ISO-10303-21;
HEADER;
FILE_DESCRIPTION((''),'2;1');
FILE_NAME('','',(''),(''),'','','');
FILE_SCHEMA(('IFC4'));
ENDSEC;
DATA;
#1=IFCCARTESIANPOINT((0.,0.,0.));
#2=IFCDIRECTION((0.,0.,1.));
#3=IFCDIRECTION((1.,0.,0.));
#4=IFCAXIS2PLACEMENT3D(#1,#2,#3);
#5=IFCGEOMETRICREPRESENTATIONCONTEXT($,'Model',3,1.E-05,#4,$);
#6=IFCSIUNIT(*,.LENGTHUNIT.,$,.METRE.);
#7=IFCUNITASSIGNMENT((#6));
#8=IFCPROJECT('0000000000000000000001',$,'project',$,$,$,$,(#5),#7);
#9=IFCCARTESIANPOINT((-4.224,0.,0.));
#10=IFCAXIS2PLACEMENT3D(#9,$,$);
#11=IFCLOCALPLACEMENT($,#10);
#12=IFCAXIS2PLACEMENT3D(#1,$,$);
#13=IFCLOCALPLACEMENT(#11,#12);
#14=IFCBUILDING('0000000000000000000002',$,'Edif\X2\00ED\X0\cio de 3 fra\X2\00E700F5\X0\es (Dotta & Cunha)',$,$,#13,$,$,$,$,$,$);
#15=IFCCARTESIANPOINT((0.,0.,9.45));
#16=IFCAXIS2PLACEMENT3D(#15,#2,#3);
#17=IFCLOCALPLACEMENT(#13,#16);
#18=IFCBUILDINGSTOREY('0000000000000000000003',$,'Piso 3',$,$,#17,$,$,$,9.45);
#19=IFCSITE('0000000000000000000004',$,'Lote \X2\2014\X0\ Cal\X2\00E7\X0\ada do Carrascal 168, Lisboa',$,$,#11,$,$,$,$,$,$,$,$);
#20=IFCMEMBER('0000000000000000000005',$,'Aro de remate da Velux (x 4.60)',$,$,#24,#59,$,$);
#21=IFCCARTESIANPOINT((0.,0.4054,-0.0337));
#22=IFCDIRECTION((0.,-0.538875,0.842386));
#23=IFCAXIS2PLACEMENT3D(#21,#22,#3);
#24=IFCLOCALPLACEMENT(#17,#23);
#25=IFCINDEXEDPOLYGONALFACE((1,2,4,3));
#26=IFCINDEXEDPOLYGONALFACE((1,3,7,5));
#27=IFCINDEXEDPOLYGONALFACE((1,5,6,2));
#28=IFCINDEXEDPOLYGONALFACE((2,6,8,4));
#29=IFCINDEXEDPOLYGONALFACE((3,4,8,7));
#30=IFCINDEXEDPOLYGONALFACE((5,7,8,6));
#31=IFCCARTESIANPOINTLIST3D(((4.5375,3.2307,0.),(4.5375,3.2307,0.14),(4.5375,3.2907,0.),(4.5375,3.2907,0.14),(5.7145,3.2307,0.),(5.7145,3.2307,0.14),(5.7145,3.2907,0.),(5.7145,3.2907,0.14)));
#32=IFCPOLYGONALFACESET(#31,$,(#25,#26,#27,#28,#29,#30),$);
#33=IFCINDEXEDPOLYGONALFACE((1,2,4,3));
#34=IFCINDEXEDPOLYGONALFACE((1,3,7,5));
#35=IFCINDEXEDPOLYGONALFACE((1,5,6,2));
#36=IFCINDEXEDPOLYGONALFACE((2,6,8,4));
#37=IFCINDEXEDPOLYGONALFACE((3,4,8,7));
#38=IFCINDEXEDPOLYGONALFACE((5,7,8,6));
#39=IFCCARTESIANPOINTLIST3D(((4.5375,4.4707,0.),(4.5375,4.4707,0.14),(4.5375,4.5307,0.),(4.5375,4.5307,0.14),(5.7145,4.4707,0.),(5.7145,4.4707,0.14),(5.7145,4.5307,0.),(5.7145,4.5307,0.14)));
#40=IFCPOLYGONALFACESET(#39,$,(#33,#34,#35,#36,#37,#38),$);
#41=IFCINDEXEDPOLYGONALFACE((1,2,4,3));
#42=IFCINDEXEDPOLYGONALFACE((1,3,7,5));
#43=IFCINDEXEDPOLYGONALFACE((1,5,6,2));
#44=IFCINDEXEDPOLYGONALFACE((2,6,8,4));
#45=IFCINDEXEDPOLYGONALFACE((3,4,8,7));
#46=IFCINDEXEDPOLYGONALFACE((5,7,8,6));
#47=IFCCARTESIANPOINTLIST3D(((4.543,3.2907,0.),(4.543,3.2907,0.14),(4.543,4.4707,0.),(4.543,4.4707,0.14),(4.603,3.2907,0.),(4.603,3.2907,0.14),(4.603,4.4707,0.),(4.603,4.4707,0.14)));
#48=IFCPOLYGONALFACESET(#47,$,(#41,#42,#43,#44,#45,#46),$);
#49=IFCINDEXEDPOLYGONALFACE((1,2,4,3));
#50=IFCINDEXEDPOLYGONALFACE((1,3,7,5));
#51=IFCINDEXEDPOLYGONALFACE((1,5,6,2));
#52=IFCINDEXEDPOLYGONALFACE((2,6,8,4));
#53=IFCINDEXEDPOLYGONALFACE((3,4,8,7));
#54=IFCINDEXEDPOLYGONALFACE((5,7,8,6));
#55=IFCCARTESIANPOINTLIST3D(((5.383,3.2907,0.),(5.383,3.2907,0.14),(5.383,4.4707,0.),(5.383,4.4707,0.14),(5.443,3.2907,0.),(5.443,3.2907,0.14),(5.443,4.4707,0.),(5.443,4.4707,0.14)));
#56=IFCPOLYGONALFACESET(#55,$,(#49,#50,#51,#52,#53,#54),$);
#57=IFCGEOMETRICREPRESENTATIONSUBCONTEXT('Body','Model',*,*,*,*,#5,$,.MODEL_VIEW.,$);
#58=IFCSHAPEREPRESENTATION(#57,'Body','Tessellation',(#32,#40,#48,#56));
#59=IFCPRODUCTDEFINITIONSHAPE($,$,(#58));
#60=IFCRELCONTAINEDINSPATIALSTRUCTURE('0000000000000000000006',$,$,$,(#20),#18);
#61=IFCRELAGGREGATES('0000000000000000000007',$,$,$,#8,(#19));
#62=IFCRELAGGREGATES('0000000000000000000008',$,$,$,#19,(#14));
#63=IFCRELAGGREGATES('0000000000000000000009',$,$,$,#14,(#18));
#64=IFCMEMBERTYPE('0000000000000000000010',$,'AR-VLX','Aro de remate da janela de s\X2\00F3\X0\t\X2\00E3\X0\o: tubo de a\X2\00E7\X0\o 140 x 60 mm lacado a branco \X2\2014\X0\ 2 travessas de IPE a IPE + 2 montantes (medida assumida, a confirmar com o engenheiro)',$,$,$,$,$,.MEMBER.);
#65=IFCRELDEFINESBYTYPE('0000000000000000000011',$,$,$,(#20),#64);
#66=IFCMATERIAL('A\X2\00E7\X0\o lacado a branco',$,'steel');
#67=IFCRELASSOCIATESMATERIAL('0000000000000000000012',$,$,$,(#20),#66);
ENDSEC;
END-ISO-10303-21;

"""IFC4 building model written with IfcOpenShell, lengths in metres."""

from ifc_helpers import new_model, si_unit, frame, origin, origin_with_axes, place, context, subcontext, project, spatial, line, indexed_curve, outline, extrude, material, type_object, element, save


model = new_model("IFC4")

# Units and contexts
model_context = context("Model", 3, precision=1e-05, world=origin_with_axes())
body_context = subcontext(model_context, "Body", "Model", "MODEL_VIEW")
ifc_project = project(units=[si_unit("LENGTHUNIT", "METRE")], contexts=[model_context])

# Site, building, storey
site_placement = place(None, frame((-4.224, 0.0, 0.0)))
site = spatial("IfcSite", under=ifc_project, at=site_placement, Name="Lote — Calçada do Carrascal 168, Lisboa")
building_placement = place(site_placement, origin())
building = spatial("IfcBuilding", under=site, at=building_placement, Name="Edifício de 3 frações (Dotta & Cunha)")
storey_placement = place(building_placement, frame((0.0, 0.0, 9.45), z_axis=(0.0, 0.0, 1.0), x_axis=(1.0, 0.0, 0.0)))
storey = spatial("IfcBuildingStorey", under=building, at=storey_placement, Name="Piso 3", Elevation=9.45)

# Member
ifc_material_1 = material(Name="Aço lacado a branco", Category="steel")
member_type_1 = type_object("IfcMemberType", Name="AR-VLX", Description="Aro de remate da janela de sótão: tubo de aço 140 x 60 mm lacado a branco — 2 travessas de IPE a IPE + 2 montantes (medida assumida, a confirmar com o engenheiro)", PredefinedType="MEMBER")
member_1_placement = place(storey_placement, frame((0.0, 0.4054, -0.0337), z_axis=(0.0, -0.538875, 0.842386), x_axis=(1.0, 0.0, 0.0)))
element("IfcMember", 1, at=member_1_placement, inside=storey, type_object=member_type_1, material=ifc_material_1, Name="Aro de remate da Velux (x 4.60)", context=body_context, shape_type="SweptSolid", body=[
    extrude(outline(indexed_curve([(5.7145, 3.2307), (4.5375, 3.2307), (4.5375, 3.2907), (5.7145, 3.2907)], segments=[line(1, 2, 3, 4, 1)])), origin_with_axes(), (0.0, 0.0, 1.0), 0.14),
    extrude(outline(indexed_curve([(5.7145, 4.4707), (4.5375, 4.4707), (4.5375, 4.5307), (5.7145, 4.5307)], segments=[line(1, 2, 3, 4, 1)])), origin_with_axes(), (0.0, 0.0, 1.0), 0.14),
    extrude(outline(indexed_curve([(4.543, 3.2907), (4.543, 4.4707), (4.603, 4.4707), (4.603, 3.2907)], segments=[line(1, 2, 3, 4, 1)])), origin_with_axes(), (0.0, 0.0, 1.0), 0.14),
    extrude(outline(indexed_curve([(5.383, 3.2907), (5.383, 4.4707), (5.443, 4.4707), (5.443, 3.2907)], segments=[line(1, 2, 3, 4, 1)])), origin_with_axes(), (0.0, 0.0, 1.0), 0.14),
])

save(model, "model.ifc")
